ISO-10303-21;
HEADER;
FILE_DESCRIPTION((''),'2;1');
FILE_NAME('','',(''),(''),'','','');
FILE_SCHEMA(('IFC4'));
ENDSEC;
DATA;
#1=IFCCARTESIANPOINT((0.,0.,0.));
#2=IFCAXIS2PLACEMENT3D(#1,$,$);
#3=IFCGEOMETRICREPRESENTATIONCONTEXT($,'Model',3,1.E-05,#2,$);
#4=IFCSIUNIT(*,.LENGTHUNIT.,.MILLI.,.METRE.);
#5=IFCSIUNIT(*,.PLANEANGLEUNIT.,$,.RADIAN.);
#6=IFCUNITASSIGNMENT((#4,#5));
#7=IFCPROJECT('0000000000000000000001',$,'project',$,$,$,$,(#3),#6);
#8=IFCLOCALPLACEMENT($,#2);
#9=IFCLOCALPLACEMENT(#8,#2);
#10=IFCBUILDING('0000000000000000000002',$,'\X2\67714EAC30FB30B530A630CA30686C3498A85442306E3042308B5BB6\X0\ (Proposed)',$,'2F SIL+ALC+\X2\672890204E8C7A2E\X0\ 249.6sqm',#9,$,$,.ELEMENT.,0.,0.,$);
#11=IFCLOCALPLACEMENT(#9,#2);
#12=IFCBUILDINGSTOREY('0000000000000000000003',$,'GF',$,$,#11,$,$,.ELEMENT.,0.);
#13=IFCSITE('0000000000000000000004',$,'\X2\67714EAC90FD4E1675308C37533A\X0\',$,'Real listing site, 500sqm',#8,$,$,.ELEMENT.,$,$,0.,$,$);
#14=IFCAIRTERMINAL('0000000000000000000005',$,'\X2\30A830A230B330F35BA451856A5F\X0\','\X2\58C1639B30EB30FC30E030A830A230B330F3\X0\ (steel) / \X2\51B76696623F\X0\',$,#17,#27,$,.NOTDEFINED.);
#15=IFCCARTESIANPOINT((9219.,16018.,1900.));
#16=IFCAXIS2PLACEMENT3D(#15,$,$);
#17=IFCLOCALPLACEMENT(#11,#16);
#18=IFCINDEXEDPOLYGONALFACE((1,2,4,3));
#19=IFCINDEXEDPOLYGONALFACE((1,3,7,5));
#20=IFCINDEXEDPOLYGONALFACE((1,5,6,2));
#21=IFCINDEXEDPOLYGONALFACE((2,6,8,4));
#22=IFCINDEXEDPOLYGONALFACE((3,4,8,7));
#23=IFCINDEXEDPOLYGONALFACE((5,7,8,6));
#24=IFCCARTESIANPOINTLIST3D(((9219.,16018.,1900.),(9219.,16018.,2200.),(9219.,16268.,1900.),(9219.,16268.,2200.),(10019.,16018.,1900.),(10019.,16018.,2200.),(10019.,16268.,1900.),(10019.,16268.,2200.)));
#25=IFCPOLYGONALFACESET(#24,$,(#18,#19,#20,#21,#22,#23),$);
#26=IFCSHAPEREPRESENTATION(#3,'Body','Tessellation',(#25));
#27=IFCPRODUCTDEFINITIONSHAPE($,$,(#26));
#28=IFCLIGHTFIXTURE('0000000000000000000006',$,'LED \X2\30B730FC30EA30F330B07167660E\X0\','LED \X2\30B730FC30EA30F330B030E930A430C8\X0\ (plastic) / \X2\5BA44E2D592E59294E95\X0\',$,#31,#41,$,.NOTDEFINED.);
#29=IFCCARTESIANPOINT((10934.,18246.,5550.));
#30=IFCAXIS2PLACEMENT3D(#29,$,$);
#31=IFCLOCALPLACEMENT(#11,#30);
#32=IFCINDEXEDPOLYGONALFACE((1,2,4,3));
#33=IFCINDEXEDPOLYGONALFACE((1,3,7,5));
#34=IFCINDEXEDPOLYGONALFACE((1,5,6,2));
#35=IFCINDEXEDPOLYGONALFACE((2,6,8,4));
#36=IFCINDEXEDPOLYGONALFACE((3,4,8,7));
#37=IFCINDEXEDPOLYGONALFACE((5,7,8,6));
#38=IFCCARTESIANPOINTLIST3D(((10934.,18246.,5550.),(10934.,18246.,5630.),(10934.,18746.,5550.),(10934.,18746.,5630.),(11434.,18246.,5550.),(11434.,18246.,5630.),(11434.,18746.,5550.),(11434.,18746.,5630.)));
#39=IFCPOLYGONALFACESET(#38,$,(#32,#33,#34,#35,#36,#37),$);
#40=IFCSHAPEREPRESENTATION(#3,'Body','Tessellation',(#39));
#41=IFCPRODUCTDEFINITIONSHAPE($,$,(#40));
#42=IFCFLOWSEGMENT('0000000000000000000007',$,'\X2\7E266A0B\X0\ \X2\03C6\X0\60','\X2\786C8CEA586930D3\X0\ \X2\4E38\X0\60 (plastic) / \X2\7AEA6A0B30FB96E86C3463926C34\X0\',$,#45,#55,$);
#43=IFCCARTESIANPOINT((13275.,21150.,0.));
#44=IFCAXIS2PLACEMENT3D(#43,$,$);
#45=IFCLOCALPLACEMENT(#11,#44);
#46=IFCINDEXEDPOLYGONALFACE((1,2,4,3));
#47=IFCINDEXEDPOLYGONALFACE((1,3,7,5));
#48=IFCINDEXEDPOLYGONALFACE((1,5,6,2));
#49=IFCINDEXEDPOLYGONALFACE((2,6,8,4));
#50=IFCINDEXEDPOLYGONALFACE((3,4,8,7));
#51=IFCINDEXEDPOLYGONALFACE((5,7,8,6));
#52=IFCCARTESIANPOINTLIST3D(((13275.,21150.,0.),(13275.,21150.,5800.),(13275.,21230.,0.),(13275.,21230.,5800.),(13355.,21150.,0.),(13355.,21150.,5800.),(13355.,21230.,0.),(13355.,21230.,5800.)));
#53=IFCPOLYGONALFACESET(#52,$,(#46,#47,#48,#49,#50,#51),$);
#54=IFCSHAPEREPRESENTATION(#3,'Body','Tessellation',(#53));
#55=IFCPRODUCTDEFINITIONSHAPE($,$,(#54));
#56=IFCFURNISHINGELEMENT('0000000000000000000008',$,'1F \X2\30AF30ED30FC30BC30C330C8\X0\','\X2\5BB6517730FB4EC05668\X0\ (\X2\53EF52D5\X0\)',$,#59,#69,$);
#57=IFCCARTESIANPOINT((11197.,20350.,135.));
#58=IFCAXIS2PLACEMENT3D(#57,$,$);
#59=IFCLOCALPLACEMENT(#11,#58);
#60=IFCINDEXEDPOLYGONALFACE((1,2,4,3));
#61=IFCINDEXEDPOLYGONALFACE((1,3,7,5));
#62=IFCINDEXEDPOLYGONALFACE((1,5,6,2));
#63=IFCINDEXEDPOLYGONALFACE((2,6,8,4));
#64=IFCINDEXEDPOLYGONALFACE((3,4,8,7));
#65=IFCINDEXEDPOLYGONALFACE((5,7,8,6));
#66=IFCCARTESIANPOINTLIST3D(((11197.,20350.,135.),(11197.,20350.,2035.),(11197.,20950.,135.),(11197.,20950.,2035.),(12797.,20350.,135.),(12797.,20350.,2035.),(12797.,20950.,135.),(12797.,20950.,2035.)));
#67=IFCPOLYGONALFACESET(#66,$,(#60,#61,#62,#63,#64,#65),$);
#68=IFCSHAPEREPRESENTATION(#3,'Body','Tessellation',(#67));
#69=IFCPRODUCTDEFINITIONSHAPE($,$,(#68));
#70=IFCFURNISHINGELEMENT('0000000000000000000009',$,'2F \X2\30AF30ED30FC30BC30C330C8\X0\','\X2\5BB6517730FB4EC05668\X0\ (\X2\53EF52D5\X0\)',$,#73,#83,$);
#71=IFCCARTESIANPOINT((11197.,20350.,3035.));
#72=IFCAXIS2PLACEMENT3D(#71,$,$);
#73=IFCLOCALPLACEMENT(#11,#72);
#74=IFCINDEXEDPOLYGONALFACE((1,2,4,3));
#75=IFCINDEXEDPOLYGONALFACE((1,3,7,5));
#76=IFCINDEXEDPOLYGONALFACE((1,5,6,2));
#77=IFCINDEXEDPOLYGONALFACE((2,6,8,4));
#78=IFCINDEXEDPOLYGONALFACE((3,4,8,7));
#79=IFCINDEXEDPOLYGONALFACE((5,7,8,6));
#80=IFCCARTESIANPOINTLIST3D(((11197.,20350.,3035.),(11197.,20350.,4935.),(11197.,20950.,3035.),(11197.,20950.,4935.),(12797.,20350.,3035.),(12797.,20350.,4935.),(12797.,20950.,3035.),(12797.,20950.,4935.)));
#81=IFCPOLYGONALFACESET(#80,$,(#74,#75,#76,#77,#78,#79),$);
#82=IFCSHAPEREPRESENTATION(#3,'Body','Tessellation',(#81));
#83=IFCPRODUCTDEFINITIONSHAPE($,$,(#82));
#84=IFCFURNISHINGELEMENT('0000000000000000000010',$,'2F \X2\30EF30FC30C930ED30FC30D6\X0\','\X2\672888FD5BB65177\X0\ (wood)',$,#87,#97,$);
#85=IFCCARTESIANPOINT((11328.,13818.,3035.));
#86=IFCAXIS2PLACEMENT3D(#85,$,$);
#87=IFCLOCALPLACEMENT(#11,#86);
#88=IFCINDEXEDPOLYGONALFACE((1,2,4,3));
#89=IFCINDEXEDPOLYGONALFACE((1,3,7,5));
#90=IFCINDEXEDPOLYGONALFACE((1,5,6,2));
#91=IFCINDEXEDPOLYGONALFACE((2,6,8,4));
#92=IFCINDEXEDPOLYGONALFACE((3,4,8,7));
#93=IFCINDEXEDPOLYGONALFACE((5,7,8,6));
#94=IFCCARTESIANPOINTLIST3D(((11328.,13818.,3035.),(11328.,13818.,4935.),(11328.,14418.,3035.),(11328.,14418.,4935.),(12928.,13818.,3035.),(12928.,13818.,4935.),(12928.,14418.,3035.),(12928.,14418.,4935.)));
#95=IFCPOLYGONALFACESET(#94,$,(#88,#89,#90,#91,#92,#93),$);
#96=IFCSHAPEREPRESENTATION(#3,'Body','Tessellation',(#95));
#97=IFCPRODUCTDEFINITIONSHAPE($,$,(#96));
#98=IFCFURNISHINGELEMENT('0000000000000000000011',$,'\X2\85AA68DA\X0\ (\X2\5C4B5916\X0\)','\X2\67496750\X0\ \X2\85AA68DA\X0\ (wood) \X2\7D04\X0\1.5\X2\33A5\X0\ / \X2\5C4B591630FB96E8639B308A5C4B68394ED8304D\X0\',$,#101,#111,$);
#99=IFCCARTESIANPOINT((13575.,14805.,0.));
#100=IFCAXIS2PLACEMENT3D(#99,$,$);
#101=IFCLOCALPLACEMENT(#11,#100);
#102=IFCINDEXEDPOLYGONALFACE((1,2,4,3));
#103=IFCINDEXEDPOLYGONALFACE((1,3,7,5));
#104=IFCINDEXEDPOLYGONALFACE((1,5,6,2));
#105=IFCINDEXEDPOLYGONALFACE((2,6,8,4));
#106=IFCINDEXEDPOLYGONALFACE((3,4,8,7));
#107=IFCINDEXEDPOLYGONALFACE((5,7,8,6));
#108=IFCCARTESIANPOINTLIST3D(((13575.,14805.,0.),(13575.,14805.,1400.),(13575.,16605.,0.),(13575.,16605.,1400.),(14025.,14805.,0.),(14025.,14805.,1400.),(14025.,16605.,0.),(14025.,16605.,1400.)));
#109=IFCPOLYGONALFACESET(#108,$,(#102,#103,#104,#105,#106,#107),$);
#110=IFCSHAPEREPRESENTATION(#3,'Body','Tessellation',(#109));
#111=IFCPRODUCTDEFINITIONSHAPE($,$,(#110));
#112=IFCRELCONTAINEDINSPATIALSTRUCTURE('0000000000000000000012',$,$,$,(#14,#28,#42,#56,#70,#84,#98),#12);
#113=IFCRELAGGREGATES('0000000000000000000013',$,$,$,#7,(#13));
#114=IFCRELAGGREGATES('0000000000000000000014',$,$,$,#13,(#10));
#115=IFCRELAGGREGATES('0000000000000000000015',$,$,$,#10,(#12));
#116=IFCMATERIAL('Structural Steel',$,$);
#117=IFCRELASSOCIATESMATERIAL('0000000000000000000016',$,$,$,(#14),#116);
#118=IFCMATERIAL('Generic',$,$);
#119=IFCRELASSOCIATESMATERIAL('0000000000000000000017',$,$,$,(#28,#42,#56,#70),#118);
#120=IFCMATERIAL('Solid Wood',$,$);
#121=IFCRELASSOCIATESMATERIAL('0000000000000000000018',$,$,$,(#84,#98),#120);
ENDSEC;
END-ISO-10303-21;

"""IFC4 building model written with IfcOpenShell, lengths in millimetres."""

from ifc_helpers import new_model, si_unit, frame, frame_2d, origin, place, context, project, spatial, rectangle, extrude, material, element, save


model = new_model("IFC4")

# Units and contexts
model_context = context("Model", 3, precision=1e-05, world=origin())
ifc_project = project(units=[si_unit("LENGTHUNIT", "METRE", prefix="MILLI"), si_unit("PLANEANGLEUNIT", "RADIAN")], contexts=[model_context])

# Site, building, storey
site_placement = place(None, origin())
site = spatial("IfcSite", under=ifc_project, at=site_placement, Name="東京都世田谷区", ObjectType="Real listing site, 500sqm", CompositionType="ELEMENT", RefElevation=0.0)
building_placement = place(site_placement, origin())
building = spatial("IfcBuilding", under=site, at=building_placement, Name="東京・サウナと水風呂のある家 (Proposed)", ObjectType="2F SIL+ALC+木造二種 249.6sqm", CompositionType="ELEMENT", ElevationOfRefHeight=0.0, ElevationOfTerrain=0.0)
storey_placement = place(building_placement, origin())
storey = spatial("IfcBuildingStorey", under=building, at=storey_placement, Name="GF", CompositionType="ELEMENT", Elevation=0.0)

# Shared definitions
ifc_material_1 = material(Name="Solid Wood")

# Shared definitions
ifc_material_2 = material(Name="Structural Steel")

# Shared definitions
ifc_material_3 = material(Name="Generic")

# Air terminal
air_terminal_placement = place(storey_placement, frame((9219.0, 16018.0, 1900.0)))
element("IfcAirTerminal", 1, at=air_terminal_placement, inside=storey, material=ifc_material_2, Name="エアコン室内機", Description="壁掛ルームエアコン (steel) / 冷暖房", PredefinedType="NOTDEFINED", context=model_context, shape_type="SweptSolid", body=[
    extrude(rectangle(XDim=800.0, YDim=250.0, at=frame_2d((400.0, 125.0))), frame((9219.0, 16018.0, 1900.0)), (0.0, 0.0, 1.0), 300.0),
])

# Light fixture
light_fixture_1_placement = place(storey_placement, frame((10934.0, 18246.0, 5550.0)))
element("IfcLightFixture", 2, at=light_fixture_1_placement, inside=storey, material=ifc_material_3, Name="LED シーリング照明", Description="LED シーリングライト (plastic) / 室中央天井", PredefinedType="NOTDEFINED", context=model_context, shape_type="SweptSolid", body=[
    extrude(rectangle(XDim=500.0, YDim=500.0, at=frame_2d((250.0, 250.0))), frame((10934.0, 18246.0, 5550.0)), (0.0, 0.0, 1.0), 80.0),
])

# Flow segment
flow_segment_placement = place(storey_placement, frame((13275.0, 21150.0, 0.0)))
element("IfcFlowSegment", 3, at=flow_segment_placement, inside=storey, material=ifc_material_3, Name="縦樋 φ60", Description="硬質塩ビ 丸60 (plastic) / 竪樋・雨水排水", context=model_context, shape_type="SweptSolid", body=[
    extrude(rectangle(XDim=80.0, YDim=80.0, at=frame_2d((40.0, 40.0))), frame((13275.0, 21150.0, 0.0)), (0.0, 0.0, 1.0), 5800.0),
])

# Furnishing elements
furnishing_1_placement = place(storey_placement, frame((11197.0, 20350.0, 135.0)))
element("IfcFurnishingElement", 4, at=furnishing_1_placement, inside=storey, material=ifc_material_3, Name="1F クローゼット", Description="家具・什器 (可動)", context=model_context, shape_type="SweptSolid", body=[
    extrude(rectangle(XDim=1600.0, YDim=600.0, at=frame_2d((800.0, 300.0))), frame((11197.0, 20350.0, 135.0)), (0.0, 0.0, 1.0), 1900.0),
])
furnishing_2_placement = place(storey_placement, frame((11197.0, 20350.0, 3035.0)))
element("IfcFurnishingElement", 5, at=furnishing_2_placement, inside=storey, material=ifc_material_3, Name="2F クローゼット", Description="家具・什器 (可動)", context=model_context, shape_type="SweptSolid", body=[
    extrude(rectangle(XDim=1600.0, YDim=600.0, at=frame_2d((800.0, 300.0))), frame((11197.0, 20350.0, 3035.0)), (0.0, 0.0, 1.0), 1900.0),
])
furnishing_3_placement = place(storey_placement, frame((11328.0, 13818.0, 3035.0)))
element("IfcFurnishingElement", 6, at=furnishing_3_placement, inside=storey, material=ifc_material_1, Name="2F ワードローブ", Description="木製家具 (wood)", context=model_context, shape_type="SweptSolid", body=[
    extrude(rectangle(XDim=1600.0, YDim=600.0, at=frame_2d((800.0, 300.0))), frame((11328.0, 13818.0, 3035.0)), (0.0, 0.0, 1.0), 1900.0),
])
furnishing_4_placement = place(storey_placement, frame((13575.0, 14805.0, 0.0)))
element("IfcFurnishingElement", 7, at=furnishing_4_placement, inside=storey, material=ifc_material_1, Name="薪棚 (屋外)", Description="杉材 薪棚 (wood) 約1.5㎥ / 屋外・雨掛り屋根付き", context=model_context, shape_type="SweptSolid", body=[
    extrude(rectangle(XDim=450.0, YDim=1800.0, at=frame_2d((225.0, 900.0))), frame((13575.0, 14805.0, 0.0)), (0.0, 0.0, 1.0), 1400.0),
])

save(model, "model.ifc")
